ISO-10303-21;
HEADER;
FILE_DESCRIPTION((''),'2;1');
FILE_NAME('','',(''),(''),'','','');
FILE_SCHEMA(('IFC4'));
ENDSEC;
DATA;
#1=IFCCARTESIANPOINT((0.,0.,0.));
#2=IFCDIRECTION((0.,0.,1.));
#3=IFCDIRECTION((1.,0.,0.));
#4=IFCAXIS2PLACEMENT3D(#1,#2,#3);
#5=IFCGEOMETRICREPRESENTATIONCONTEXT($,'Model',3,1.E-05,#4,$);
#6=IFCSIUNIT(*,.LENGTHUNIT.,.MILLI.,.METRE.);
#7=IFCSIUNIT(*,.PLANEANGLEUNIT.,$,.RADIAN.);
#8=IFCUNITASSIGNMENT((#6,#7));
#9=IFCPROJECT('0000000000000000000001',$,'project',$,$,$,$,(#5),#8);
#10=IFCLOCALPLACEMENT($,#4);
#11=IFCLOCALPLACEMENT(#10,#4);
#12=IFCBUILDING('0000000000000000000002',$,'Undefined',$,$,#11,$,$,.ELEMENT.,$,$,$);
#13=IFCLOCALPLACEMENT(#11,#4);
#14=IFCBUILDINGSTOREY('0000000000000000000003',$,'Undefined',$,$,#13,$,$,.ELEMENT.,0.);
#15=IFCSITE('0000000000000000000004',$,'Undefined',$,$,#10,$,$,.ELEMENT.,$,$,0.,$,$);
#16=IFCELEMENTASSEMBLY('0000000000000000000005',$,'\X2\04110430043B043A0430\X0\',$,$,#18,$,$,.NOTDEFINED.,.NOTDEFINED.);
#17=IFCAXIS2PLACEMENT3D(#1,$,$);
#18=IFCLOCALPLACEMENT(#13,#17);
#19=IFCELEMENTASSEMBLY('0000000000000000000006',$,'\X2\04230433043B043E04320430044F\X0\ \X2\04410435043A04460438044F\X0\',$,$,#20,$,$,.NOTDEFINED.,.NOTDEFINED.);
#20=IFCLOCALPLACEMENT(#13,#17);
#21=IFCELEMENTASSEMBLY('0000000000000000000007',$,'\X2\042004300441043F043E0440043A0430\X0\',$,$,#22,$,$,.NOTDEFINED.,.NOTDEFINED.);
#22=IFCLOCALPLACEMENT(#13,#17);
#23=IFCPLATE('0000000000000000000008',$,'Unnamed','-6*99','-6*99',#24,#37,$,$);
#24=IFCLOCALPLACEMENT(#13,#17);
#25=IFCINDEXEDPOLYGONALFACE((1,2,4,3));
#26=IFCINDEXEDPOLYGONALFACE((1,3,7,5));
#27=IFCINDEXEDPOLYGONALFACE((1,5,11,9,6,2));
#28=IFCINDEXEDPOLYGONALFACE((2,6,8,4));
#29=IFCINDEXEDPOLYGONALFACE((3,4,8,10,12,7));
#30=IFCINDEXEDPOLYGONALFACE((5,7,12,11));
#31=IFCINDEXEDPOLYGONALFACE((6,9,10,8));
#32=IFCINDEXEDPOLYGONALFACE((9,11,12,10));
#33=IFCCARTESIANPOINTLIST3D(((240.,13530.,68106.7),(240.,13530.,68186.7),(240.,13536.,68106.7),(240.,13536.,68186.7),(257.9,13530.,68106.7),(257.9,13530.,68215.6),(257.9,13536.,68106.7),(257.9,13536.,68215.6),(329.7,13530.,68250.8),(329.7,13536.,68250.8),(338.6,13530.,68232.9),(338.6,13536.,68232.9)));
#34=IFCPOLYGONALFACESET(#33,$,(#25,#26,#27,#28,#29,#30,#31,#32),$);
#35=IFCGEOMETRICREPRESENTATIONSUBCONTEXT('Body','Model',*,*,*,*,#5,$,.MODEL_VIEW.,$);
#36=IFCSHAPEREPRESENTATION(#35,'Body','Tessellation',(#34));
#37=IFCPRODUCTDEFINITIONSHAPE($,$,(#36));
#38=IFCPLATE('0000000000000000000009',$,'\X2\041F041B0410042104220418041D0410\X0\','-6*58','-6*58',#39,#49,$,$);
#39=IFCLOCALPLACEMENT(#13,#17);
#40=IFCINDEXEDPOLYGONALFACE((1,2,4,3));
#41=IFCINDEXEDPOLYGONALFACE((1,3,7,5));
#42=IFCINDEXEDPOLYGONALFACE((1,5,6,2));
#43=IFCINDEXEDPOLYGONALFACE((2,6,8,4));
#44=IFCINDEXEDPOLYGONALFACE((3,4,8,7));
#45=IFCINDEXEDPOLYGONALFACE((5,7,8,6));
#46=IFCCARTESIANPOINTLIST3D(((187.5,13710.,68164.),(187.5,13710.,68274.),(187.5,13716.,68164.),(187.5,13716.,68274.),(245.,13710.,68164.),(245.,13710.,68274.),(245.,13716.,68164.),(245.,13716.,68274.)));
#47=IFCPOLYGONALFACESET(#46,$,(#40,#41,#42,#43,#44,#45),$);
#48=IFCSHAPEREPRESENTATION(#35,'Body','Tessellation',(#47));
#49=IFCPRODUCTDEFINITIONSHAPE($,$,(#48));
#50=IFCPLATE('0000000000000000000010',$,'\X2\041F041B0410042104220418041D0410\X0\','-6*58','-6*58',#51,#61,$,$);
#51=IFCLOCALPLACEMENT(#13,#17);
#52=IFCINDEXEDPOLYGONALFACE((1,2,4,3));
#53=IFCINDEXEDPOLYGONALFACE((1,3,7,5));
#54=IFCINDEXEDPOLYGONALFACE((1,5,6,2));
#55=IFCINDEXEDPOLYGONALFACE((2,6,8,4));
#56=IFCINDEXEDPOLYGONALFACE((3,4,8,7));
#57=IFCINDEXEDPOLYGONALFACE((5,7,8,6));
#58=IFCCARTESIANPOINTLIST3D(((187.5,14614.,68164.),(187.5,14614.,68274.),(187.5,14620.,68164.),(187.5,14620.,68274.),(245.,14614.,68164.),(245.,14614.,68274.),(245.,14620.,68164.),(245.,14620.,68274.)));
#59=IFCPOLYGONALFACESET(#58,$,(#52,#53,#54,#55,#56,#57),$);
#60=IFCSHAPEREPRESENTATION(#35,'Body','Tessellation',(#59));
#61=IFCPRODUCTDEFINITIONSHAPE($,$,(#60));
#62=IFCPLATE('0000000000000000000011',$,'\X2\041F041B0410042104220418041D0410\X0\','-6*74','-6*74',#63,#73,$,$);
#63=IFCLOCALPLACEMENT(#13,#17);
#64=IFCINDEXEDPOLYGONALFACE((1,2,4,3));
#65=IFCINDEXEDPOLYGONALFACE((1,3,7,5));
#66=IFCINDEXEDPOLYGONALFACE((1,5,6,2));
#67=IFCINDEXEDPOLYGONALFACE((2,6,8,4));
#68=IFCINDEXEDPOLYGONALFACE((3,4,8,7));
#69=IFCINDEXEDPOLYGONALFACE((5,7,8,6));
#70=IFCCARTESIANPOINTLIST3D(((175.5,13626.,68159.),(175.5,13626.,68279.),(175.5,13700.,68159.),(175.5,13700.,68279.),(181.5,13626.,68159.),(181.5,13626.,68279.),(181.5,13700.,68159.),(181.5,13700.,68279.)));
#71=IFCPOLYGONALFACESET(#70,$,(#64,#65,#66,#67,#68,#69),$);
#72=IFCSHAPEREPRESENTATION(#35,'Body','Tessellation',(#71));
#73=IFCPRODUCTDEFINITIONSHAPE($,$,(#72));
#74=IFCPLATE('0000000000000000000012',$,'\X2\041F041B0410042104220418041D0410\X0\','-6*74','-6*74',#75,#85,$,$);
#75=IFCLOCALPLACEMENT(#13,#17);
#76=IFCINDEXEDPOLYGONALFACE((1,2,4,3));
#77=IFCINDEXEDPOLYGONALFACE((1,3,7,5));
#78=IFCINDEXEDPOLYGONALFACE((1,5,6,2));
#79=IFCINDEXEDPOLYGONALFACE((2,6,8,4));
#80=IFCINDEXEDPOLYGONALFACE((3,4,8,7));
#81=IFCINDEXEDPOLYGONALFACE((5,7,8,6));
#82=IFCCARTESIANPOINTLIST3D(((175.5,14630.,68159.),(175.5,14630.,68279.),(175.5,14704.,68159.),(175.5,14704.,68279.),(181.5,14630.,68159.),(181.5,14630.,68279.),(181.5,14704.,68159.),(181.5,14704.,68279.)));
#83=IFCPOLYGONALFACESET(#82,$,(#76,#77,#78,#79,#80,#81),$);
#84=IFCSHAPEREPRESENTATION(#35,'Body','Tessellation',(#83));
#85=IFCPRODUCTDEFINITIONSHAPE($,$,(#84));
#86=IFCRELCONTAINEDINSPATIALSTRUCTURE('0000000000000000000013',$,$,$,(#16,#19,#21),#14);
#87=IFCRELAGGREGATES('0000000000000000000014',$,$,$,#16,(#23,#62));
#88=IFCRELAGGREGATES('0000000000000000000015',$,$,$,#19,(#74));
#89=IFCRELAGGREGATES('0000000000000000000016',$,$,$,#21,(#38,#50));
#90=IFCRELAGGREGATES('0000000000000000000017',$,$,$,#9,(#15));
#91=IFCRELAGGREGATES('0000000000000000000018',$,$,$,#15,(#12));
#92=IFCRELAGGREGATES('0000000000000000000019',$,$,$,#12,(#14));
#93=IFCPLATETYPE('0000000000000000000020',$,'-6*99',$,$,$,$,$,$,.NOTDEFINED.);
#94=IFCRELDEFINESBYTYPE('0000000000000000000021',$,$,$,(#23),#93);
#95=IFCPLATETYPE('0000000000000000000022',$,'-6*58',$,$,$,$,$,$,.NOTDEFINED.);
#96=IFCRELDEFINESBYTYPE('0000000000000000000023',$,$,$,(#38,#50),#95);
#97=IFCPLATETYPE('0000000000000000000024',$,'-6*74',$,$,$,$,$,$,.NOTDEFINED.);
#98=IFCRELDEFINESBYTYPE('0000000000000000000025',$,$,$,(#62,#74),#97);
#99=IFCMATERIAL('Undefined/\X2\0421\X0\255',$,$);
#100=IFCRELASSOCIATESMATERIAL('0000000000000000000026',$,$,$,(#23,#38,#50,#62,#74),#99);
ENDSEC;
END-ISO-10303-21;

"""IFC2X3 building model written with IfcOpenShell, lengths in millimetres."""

from ifc_helpers import new_model, si_unit, frame, origin_with_axes, place, context, subcontext, project, spatial, polyline, outline, extrude, material, type_object, element, aggregate, save


model = new_model("IFC2X3")

# Units and contexts
model_context = context("Model", 3, precision=1e-05, world=origin_with_axes())
body_context = subcontext(model_context, "Body", "Model", "MODEL_VIEW")
ifc_project = project(units=[si_unit("LENGTHUNIT", "METRE", prefix="MILLI"), si_unit("PLANEANGLEUNIT", "RADIAN")], contexts=[model_context])

# Site, building, storey
site_placement = place(None, origin_with_axes())
site = spatial("IfcSite", under=ifc_project, at=site_placement, Name="Undefined", CompositionType="ELEMENT", RefElevation=0.0)
building_placement = place(site_placement, origin_with_axes())
building = spatial("IfcBuilding", under=site, at=building_placement, Name="Undefined", CompositionType="ELEMENT")
storey_placement = place(building_placement, origin_with_axes())
storey = spatial("IfcBuildingStorey", under=building, at=storey_placement, Name="Undefined", CompositionType="ELEMENT", Elevation=0.0)

# Element assembly
assembly_1_placement = place(storey_placement, origin_with_axes())
assembly_1 = element("IfcElementAssembly", 1, at=assembly_1_placement, inside=storey, Name="Балка", AssemblyPlace="NOTDEFINED", PredefinedType="NOTDEFINED")
ifc_material_1 = material(Name="Undefined/С255")

# Element assembly
assembly_2_placement = place(storey_placement, origin_with_axes())
assembly_2 = element("IfcElementAssembly", 2, at=assembly_2_placement, inside=storey, Name="Угловая секция", AssemblyPlace="NOTDEFINED", PredefinedType="NOTDEFINED")

# Element assembly
assembly_3_placement = place(storey_placement, origin_with_axes())
assembly_3 = element("IfcElementAssembly", 3, at=assembly_3_placement, inside=storey, Name="Распорка", AssemblyPlace="NOTDEFINED", PredefinedType="NOTDEFINED")

# Plates
plate_type_1 = type_object("IfcPlateType", Name="-6*99", PredefinedType="NOTDEFINED")
plate_1_placement = place(assembly_1_placement, frame((240.0, 13533.0, 68106.7), z_axis=(0.0, 1.0, 0.0), x_axis=(0.0, 0.0, 1.0)))
plate_1 = element("IfcPlate", 4, at=plate_1_placement, type_object=plate_type_1, material=ifc_material_1, Name="Unnamed", Description="-6*99", ObjectType="-6*99", context=body_context, shape_type="SweptSolid", body=[
    extrude(outline(polyline([(0.0, 0.0), (80.0, 0.0), (108.8, 17.9), (144.1, 89.7), (126.2, 98.6), (0.0, 17.9), (0.0, 0.0)])), frame((0.0, 0.0, -3.0), z_axis=(0.0, 0.0, 1.0), x_axis=(1.0, 0.0, 0.0)), (0.0, 0.0, 1.0), 6.0),
])
plate_type_2 = type_object("IfcPlateType", Name="-6*58", PredefinedType="NOTDEFINED")
plate_2_placement = place(assembly_3_placement, frame((245.0, 13713.0, 68164.0), z_axis=(0.0, 1.0, 0.0), x_axis=(-1.0, 0.0, 0.0)))
plate_2 = element("IfcPlate", 5, at=plate_2_placement, type_object=plate_type_2, material=ifc_material_1, Name="ПЛАСТИНА", Description="-6*58", ObjectType="-6*58", context=body_context, shape_type="SweptSolid", body=[
    extrude(outline(polyline([(0.0, 0.0), (57.5, 0.0), (57.5, 110.0), (0.0, 110.0), (0.0, 0.0)])), frame((0.0, 0.0, -3.0), z_axis=(0.0, 0.0, 1.0), x_axis=(1.0, 0.0, 0.0)), (0.0, 0.0, 1.0), 6.0),
])
plate_3_placement = place(assembly_3_placement, frame((245.0, 14617.0, 68274.0), z_axis=(0.0, -1.0, 0.0), x_axis=(-1.0, 0.0, 0.0)))
plate_3 = element("IfcPlate", 6, at=plate_3_placement, type_object=plate_type_2, material=ifc_material_1, Name="ПЛАСТИНА", Description="-6*58", ObjectType="-6*58", context=body_context, shape_type="SweptSolid", body=[
    extrude(outline(polyline([(0.0, 0.0), (57.5, 0.0), (57.5, 110.0), (0.0, 110.0), (0.0, 0.0)])), frame((0.0, 0.0, -3.0), z_axis=(0.0, 0.0, 1.0), x_axis=(1.0, 0.0, 0.0)), (0.0, 0.0, 1.0), 6.0),
])
plate_type_3 = type_object("IfcPlateType", Name="-6*74", PredefinedType="NOTDEFINED")
plate_4_placement = place(assembly_1_placement, frame((178.5, 13626.0, 68279.0), z_axis=(1.0, 0.0, 0.0), x_axis=(0.0, 0.0, -1.0)))
plate_4 = element("IfcPlate", 7, at=plate_4_placement, type_object=plate_type_3, material=ifc_material_1, Name="ПЛАСТИНА", Description="-6*74", ObjectType="-6*74", context=body_context, shape_type="SweptSolid", body=[
    extrude(outline(polyline([(0.0, 0.0), (120.0, 0.0), (120.0, 74.0), (0.0, 74.0), (0.0, 0.0)])), frame((0.0, 0.0, -3.0), z_axis=(0.0, 0.0, 1.0), x_axis=(1.0, 0.0, 0.0)), (0.0, 0.0, 1.0), 6.0),
])
aggregate(assembly_1, [plate_1, plate_4])
plate_5_placement = place(assembly_2_placement, frame((178.5, 14704.0, 68159.0), z_axis=(1.0, 0.0, 0.0), x_axis=(0.0, 0.0, 1.0)))
plate_5 = element("IfcPlate", 8, at=plate_5_placement, type_object=plate_type_3, material=ifc_material_1, Name="ПЛАСТИНА", Description="-6*74", ObjectType="-6*74", context=body_context, shape_type="SweptSolid", body=[
    extrude(outline(polyline([(0.0, 0.0), (120.0, 0.0), (120.0, 74.0), (0.0, 74.0), (0.0, 0.0)])), frame((0.0, 0.0, -3.0), z_axis=(0.0, 0.0, 1.0), x_axis=(1.0, 0.0, 0.0)), (0.0, 0.0, 1.0), 6.0),
])
aggregate(assembly_2, [plate_5])

aggregate(assembly_3, [plate_2, plate_3])

save(model, "model.ifc")
